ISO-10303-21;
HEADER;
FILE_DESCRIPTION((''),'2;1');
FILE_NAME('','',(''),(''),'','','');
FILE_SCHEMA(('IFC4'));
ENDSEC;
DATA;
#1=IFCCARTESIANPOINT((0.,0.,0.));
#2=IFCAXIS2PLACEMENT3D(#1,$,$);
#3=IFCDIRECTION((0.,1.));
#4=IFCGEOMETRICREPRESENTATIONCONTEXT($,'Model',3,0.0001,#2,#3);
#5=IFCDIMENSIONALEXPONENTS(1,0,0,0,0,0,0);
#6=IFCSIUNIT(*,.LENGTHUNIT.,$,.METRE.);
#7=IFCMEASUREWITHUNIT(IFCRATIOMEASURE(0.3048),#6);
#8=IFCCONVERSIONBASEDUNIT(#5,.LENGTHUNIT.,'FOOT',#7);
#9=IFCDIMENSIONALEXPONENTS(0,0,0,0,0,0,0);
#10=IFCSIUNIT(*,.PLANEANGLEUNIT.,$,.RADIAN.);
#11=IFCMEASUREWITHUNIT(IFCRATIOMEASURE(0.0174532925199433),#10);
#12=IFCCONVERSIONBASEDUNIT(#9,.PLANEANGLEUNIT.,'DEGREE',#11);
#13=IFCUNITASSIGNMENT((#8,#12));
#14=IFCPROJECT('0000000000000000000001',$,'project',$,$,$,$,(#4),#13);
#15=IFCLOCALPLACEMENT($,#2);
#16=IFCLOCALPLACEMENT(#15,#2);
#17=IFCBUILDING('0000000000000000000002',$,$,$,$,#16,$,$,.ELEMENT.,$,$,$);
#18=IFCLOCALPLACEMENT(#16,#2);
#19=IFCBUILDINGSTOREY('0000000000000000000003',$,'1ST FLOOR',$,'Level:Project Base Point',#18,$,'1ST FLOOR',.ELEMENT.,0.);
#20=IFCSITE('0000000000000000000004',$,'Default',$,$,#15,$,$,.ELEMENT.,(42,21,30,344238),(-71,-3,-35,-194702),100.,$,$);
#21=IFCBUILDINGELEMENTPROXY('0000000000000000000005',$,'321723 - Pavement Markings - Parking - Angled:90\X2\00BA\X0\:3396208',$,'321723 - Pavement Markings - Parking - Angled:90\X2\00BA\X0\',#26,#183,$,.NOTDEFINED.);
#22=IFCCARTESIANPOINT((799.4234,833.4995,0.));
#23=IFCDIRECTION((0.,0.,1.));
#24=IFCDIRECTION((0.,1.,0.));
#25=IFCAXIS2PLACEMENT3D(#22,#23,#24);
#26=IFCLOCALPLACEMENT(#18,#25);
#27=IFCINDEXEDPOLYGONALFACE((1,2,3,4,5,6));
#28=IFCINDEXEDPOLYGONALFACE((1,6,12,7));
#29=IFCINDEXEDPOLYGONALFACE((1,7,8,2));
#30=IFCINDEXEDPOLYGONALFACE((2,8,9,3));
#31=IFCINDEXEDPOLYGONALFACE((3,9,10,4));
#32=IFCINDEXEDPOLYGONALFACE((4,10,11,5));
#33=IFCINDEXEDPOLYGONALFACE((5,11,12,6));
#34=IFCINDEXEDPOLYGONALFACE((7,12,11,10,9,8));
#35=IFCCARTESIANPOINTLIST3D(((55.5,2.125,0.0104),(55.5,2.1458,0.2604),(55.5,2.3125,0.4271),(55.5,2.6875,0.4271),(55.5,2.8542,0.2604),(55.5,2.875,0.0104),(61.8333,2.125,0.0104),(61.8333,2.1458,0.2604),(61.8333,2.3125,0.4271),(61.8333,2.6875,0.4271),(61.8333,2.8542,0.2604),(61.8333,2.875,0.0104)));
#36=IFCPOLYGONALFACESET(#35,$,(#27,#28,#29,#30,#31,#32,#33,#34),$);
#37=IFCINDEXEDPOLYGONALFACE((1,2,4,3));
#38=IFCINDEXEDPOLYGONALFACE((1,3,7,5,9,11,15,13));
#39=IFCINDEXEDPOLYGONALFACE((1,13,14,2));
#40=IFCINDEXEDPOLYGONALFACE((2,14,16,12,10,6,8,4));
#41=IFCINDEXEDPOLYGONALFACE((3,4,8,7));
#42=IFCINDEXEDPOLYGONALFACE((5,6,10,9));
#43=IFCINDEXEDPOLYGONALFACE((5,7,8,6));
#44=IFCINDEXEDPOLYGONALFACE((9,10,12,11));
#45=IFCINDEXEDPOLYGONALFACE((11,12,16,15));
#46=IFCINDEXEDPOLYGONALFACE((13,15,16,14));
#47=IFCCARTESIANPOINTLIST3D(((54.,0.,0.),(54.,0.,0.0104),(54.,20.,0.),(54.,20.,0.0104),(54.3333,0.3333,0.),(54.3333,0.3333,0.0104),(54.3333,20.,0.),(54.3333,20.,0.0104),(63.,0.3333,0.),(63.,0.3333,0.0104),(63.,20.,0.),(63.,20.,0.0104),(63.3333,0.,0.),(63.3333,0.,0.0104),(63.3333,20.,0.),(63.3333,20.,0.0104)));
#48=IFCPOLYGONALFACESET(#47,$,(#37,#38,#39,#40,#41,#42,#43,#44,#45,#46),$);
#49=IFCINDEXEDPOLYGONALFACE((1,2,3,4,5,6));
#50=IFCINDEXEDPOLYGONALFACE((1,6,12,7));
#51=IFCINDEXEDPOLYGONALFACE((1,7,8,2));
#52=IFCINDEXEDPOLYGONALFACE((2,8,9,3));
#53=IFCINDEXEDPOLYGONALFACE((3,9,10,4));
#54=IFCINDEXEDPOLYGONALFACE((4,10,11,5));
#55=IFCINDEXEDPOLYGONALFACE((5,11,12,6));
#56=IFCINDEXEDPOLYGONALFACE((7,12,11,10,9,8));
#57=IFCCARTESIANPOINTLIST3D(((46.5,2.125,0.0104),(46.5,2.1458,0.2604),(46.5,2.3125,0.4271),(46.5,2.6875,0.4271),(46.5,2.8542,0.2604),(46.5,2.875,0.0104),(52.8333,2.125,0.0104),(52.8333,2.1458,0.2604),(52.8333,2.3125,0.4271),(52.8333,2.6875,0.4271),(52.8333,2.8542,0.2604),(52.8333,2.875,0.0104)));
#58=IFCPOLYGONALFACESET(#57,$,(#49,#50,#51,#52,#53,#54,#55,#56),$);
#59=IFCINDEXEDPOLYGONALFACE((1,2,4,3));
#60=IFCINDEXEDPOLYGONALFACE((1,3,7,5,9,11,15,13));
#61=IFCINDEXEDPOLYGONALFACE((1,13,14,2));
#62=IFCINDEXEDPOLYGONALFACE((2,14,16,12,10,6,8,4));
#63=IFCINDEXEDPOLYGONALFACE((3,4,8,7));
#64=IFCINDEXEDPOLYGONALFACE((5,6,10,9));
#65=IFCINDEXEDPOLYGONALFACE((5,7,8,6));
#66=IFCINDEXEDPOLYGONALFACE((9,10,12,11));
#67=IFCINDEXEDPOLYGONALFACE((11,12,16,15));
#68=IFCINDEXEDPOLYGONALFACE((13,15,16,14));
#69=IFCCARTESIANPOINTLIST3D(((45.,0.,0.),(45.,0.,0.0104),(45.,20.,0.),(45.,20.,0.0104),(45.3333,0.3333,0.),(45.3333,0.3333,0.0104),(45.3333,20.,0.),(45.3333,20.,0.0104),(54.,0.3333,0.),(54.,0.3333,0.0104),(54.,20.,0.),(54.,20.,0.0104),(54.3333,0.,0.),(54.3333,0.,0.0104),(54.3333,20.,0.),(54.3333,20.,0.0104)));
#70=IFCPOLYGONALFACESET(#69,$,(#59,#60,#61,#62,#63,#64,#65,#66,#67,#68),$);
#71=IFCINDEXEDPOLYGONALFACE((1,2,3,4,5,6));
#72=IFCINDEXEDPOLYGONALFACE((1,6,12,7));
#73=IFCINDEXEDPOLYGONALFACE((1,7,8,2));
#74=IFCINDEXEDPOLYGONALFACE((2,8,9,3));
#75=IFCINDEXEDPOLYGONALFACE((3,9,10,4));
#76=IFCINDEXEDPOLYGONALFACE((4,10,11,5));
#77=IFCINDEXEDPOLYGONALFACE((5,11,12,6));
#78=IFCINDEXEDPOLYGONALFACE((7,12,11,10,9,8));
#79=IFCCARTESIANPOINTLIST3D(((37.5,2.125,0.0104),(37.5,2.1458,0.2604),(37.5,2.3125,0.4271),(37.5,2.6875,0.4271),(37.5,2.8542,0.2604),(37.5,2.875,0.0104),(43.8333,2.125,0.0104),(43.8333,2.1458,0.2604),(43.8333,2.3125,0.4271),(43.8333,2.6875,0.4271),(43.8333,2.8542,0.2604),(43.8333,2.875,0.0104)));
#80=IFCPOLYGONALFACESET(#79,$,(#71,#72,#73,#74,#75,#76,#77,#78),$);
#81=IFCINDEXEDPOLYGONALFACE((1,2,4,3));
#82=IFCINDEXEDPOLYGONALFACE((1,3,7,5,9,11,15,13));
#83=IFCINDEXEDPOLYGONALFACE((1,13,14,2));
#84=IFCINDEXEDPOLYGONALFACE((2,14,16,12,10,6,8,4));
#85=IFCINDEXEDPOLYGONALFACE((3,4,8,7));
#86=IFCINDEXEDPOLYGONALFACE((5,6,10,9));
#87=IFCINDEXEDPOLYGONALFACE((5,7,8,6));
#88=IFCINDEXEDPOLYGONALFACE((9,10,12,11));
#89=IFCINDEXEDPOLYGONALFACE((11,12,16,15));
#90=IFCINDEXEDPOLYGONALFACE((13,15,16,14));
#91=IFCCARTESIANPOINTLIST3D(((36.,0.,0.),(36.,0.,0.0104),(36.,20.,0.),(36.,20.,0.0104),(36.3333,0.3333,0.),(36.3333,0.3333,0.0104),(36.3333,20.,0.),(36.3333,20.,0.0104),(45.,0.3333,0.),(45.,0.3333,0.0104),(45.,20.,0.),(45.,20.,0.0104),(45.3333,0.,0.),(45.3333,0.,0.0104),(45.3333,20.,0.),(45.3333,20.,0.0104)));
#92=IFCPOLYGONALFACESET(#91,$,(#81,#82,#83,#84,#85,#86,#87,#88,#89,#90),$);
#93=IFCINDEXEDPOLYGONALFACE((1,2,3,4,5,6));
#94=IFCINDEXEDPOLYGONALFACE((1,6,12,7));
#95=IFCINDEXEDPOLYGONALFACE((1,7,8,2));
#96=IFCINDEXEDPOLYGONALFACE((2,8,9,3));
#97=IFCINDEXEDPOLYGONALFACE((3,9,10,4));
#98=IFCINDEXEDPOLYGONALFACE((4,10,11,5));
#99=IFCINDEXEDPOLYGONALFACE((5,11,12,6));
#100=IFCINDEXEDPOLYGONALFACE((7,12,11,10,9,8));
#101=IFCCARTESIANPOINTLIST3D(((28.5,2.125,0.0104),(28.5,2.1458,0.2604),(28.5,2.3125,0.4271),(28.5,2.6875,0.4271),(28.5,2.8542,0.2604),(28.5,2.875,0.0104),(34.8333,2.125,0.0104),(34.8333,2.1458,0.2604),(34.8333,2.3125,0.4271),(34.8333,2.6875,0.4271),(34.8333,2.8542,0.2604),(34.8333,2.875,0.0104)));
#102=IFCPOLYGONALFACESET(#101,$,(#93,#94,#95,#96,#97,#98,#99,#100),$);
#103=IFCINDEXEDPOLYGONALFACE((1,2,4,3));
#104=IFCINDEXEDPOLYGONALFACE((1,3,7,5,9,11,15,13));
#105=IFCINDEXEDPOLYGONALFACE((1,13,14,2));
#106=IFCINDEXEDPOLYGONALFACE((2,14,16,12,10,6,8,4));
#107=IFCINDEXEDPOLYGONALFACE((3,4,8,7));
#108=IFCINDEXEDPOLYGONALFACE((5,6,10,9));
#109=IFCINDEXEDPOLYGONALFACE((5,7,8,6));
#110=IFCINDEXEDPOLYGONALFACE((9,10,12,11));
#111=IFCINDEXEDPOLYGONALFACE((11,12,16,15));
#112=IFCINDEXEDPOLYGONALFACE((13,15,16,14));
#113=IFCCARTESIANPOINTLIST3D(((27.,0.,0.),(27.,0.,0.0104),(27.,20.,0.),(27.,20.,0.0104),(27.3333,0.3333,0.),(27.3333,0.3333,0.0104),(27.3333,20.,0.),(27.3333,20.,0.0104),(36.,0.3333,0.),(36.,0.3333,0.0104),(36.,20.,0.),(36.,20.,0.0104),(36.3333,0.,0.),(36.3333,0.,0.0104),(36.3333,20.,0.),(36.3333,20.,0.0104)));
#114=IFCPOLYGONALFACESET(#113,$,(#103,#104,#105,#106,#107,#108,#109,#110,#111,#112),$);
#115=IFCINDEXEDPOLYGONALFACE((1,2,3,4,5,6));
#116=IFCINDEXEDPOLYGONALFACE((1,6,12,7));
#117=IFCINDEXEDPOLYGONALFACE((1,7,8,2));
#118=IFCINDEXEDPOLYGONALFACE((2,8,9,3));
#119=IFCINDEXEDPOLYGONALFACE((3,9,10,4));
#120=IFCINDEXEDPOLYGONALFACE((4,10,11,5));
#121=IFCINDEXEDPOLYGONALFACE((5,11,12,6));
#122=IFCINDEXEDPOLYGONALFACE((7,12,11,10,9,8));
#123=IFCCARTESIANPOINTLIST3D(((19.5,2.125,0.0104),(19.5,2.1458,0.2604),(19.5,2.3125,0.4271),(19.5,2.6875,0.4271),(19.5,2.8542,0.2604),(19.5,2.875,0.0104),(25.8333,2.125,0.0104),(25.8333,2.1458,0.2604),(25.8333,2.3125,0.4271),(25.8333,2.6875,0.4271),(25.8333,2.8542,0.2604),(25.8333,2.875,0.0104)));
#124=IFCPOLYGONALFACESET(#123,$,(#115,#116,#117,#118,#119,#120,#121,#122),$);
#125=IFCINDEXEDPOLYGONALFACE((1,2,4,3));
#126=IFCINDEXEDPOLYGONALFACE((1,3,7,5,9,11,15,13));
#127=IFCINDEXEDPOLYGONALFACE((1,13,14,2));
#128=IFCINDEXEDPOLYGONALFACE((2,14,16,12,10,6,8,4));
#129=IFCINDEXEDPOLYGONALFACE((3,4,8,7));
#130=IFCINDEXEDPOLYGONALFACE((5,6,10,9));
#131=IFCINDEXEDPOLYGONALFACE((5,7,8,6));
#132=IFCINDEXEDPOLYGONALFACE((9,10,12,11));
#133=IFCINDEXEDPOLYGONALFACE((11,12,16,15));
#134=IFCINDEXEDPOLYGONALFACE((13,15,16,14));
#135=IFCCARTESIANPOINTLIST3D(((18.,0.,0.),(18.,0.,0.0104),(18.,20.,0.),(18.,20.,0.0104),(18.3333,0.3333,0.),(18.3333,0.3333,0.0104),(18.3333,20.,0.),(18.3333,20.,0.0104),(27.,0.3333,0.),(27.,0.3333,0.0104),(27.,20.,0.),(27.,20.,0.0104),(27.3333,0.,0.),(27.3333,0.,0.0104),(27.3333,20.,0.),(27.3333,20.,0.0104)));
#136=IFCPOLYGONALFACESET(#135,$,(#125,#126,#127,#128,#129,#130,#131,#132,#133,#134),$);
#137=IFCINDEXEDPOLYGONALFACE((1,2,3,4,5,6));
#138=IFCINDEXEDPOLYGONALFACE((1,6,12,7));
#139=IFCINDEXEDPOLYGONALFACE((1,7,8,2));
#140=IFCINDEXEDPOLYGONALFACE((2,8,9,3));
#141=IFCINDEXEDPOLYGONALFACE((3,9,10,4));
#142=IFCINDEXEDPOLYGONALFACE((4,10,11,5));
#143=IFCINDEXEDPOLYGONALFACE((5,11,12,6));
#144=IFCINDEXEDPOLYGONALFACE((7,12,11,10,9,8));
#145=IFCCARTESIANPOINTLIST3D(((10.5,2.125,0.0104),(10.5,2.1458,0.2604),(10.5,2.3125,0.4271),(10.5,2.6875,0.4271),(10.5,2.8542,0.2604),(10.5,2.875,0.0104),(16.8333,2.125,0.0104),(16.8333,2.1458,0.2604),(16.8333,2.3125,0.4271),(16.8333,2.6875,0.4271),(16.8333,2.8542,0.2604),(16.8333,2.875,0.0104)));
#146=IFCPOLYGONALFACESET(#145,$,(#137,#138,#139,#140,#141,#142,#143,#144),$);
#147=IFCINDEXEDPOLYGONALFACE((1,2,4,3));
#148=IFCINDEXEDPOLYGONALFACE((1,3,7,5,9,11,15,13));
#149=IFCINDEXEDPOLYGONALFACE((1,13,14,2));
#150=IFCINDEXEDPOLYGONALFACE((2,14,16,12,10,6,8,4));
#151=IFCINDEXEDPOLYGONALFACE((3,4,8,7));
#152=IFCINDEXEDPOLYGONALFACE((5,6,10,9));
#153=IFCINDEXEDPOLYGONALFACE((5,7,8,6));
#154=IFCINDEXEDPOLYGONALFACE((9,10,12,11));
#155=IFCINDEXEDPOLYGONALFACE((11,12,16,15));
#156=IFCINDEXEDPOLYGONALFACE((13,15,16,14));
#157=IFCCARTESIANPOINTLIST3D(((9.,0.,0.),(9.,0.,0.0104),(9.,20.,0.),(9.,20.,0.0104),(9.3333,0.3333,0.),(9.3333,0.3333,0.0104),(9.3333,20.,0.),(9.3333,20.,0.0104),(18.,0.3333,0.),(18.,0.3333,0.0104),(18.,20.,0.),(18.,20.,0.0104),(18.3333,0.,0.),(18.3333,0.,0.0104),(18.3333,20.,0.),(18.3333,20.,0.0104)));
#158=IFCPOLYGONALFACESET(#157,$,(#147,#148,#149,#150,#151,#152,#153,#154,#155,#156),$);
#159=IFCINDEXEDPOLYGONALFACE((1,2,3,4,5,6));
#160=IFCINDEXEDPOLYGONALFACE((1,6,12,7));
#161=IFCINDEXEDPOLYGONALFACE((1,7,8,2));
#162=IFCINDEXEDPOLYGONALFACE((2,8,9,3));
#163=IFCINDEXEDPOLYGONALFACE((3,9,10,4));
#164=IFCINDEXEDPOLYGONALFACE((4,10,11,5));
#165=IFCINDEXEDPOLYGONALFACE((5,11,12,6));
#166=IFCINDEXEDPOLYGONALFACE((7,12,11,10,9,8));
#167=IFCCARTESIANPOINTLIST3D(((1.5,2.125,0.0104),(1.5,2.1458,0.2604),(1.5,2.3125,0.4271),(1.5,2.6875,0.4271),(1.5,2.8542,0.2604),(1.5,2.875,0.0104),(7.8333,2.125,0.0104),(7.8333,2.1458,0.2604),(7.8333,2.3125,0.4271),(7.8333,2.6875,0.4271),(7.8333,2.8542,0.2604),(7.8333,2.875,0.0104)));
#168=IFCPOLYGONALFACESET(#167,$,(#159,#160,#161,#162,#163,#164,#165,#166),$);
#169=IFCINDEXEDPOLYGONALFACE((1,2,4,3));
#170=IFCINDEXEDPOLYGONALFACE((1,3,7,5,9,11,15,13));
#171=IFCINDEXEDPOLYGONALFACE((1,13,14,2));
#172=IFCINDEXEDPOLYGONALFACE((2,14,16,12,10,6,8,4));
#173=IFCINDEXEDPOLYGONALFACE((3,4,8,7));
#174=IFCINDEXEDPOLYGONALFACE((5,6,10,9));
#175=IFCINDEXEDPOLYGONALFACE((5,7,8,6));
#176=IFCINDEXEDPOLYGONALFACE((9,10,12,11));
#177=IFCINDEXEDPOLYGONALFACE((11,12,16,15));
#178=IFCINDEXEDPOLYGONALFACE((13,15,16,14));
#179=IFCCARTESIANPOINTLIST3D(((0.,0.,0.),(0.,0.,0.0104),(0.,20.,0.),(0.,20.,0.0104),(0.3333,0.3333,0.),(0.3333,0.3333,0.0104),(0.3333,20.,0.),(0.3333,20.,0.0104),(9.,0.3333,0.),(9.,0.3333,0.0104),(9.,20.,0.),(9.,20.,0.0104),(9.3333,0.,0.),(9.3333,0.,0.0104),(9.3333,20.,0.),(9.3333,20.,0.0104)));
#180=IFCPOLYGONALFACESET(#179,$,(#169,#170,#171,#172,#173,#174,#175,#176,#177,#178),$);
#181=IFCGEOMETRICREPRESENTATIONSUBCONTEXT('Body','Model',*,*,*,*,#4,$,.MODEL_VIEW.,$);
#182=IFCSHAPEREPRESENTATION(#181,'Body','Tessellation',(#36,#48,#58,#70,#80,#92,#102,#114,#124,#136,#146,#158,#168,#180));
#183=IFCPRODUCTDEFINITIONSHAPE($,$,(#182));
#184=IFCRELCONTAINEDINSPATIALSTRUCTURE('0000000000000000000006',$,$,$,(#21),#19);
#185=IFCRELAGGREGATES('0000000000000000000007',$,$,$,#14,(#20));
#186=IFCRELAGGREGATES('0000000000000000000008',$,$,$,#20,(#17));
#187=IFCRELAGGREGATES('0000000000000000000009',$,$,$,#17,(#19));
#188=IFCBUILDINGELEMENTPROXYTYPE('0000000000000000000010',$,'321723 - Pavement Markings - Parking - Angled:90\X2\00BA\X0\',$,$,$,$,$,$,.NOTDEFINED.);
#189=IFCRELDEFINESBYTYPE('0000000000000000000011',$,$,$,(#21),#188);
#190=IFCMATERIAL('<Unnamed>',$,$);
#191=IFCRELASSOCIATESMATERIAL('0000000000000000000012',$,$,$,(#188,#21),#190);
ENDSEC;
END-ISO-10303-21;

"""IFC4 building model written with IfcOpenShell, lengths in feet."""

from ifc_helpers import new_model, entity, si_unit, converted_unit, direction, frame, origin, place, context, subcontext, project, spatial, polyline, outline, extrude, source, transform, mapped, material, type_object, type_shapes, element, save


model = new_model("IFC4")

# Units and contexts
model_context = context("Model", 3, precision=0.0001, world=origin(), true_north=direction((0.0, 1.0)))
body_context = subcontext(model_context, "Body", "Model", "MODEL_VIEW")
ifc_project = project(units=[converted_unit("LENGTHUNIT", "FOOT", entity("IfcRatioMeasure", 0.3048), si_unit("LENGTHUNIT", "METRE"), dimensions=[1, 0, 0, 0, 0, 0, 0]), converted_unit("PLANEANGLEUNIT", "DEGREE", entity("IfcRatioMeasure", 0.0174532925199433), si_unit("PLANEANGLEUNIT", "RADIAN"), dimensions=[0, 0, 0, 0, 0, 0, 0])], contexts=[model_context])

# Site, building, storey
site_placement = place(None, origin())
site = spatial("IfcSite", under=ifc_project, at=site_placement, Name="Default", CompositionType="ELEMENT", RefLatitude=(42, 21, 30, 344238), RefLongitude=(-71, -3, -35, -194702), RefElevation=100.0)
building_placement = place(site_placement, origin())
building = spatial("IfcBuilding", under=site, at=building_placement, CompositionType="ELEMENT")
storey_placement = place(building_placement, origin())
storey = spatial("IfcBuildingStorey", under=building, at=storey_placement, Name="1ST FLOOR", ObjectType="Level:Project Base Point", LongName="1ST FLOOR", CompositionType="ELEMENT", Elevation=0.0)

# Building element proxy
ifc_material_1 = material(Name="<Unnamed>")
building_element_proxy_type_1 = type_object("IfcBuildingElementProxyType", Name="321723 - Pavement Markings - Parking - Angled:90º", PredefinedType="NOTDEFINED", material=ifc_material_1)
shared_shape_1 = source(origin(), body_context, "Body", "SweptSolid", [
    extrude(outline(polyline([(-0.375, -0.2222), (0.375, -0.2222), (0.3542, 0.0278), (0.1875, 0.1944), (-0.1875, 0.1944), (-0.3542, 0.0278), (-0.375, -0.2222)])), frame((55.5, 2.5, 0.2326), z_axis=(1.0, 0.0, 0.0), x_axis=(0.0, 1.0, 0.0)), (0.0, 0.0, 1.0), 6.3333),
    extrude(outline(polyline([(-4.6667, -10.0833), (4.6667, -10.0833), (4.6667, 9.9167), (4.3333, 9.9167), (4.3333, -9.75), (-4.3333, -9.75), (-4.3333, 9.9167), (-4.6667, 9.9167), (-4.6667, -10.0833)])), frame((58.6667, 10.0833, 0.0)), (0.0, 0.0, 1.0), 0.0104),
    extrude(outline(polyline([(-0.375, -0.2222), (0.375, -0.2222), (0.3542, 0.0278), (0.1875, 0.1944), (-0.1875, 0.1944), (-0.3542, 0.0278), (-0.375, -0.2222)])), frame((46.5, 2.5, 0.2326), z_axis=(1.0, 0.0, 0.0), x_axis=(0.0, 1.0, 0.0)), (0.0, 0.0, 1.0), 6.3333),
    extrude(outline(polyline([(-4.6667, -10.0833), (4.6667, -10.0833), (4.6667, 9.9167), (4.3333, 9.9167), (4.3333, -9.75), (-4.3333, -9.75), (-4.3333, 9.9167), (-4.6667, 9.9167), (-4.6667, -10.0833)])), frame((49.6667, 10.0833, 0.0)), (0.0, 0.0, 1.0), 0.0104),
    extrude(outline(polyline([(-0.375, -0.2222), (0.375, -0.2222), (0.3542, 0.0278), (0.1875, 0.1944), (-0.1875, 0.1944), (-0.3542, 0.0278), (-0.375, -0.2222)])), frame((37.5, 2.5, 0.2326), z_axis=(1.0, 0.0, 0.0), x_axis=(0.0, 1.0, 0.0)), (0.0, 0.0, 1.0), 6.3333),
    extrude(outline(polyline([(-4.6667, -10.0833), (4.6667, -10.0833), (4.6667, 9.9167), (4.3333, 9.9167), (4.3333, -9.75), (-4.3333, -9.75), (-4.3333, 9.9167), (-4.6667, 9.9167), (-4.6667, -10.0833)])), frame((40.6667, 10.0833, 0.0)), (0.0, 0.0, 1.0), 0.0104),
    extrude(outline(polyline([(-0.375, -0.2222), (0.375, -0.2222), (0.3542, 0.0278), (0.1875, 0.1944), (-0.1875, 0.1944), (-0.3542, 0.0278), (-0.375, -0.2222)])), frame((28.5, 2.5, 0.2326), z_axis=(1.0, 0.0, 0.0), x_axis=(0.0, 1.0, 0.0)), (0.0, 0.0, 1.0), 6.3333),
    extrude(outline(polyline([(-4.6667, -10.0833), (4.6667, -10.0833), (4.6667, 9.9167), (4.3333, 9.9167), (4.3333, -9.75), (-4.3333, -9.75), (-4.3333, 9.9167), (-4.6667, 9.9167), (-4.6667, -10.0833)])), frame((31.6667, 10.0833, 0.0)), (0.0, 0.0, 1.0), 0.0104),
    extrude(outline(polyline([(-0.375, -0.2222), (0.375, -0.2222), (0.3542, 0.0278), (0.1875, 0.1944), (-0.1875, 0.1944), (-0.3542, 0.0278), (-0.375, -0.2222)])), frame((19.5, 2.5, 0.2326), z_axis=(1.0, 0.0, 0.0), x_axis=(0.0, 1.0, 0.0)), (0.0, 0.0, 1.0), 6.3333),
    extrude(outline(polyline([(-4.6667, -10.0833), (4.6667, -10.0833), (4.6667, 9.9167), (4.3333, 9.9167), (4.3333, -9.75), (-4.3333, -9.75), (-4.3333, 9.9167), (-4.6667, 9.9167), (-4.6667, -10.0833)])), frame((22.6667, 10.0833, 0.0)), (0.0, 0.0, 1.0), 0.0104),
    extrude(outline(polyline([(-0.375, -0.2222), (0.375, -0.2222), (0.3542, 0.0278), (0.1875, 0.1944), (-0.1875, 0.1944), (-0.3542, 0.0278), (-0.375, -0.2222)])), frame((10.5, 2.5, 0.2326), z_axis=(1.0, 0.0, 0.0), x_axis=(0.0, 1.0, 0.0)), (0.0, 0.0, 1.0), 6.3333),
    extrude(outline(polyline([(-4.6667, -10.0833), (4.6667, -10.0833), (4.6667, 9.9167), (4.3333, 9.9167), (4.3333, -9.75), (-4.3333, -9.75), (-4.3333, 9.9167), (-4.6667, 9.9167), (-4.6667, -10.0833)])), frame((13.6667, 10.0833, 0.0)), (0.0, 0.0, 1.0), 0.0104),
    extrude(outline(polyline([(-0.375, -0.2222), (0.375, -0.2222), (0.3542, 0.0278), (0.1875, 0.1944), (-0.1875, 0.1944), (-0.3542, 0.0278), (-0.375, -0.2222)])), frame((1.5, 2.5, 0.2326), z_axis=(1.0, 0.0, 0.0), x_axis=(0.0, 1.0, 0.0)), (0.0, 0.0, 1.0), 6.3333),
    extrude(outline(polyline([(-4.6667, -10.0833), (4.6667, -10.0833), (4.6667, 9.9167), (4.3333, 9.9167), (4.3333, -9.75), (-4.3333, -9.75), (-4.3333, 9.9167), (-4.6667, 9.9167), (-4.6667, -10.0833)])), frame((4.6667, 10.0833, 0.0)), (0.0, 0.0, 1.0), 0.0104),
])
type_shapes(building_element_proxy_type_1, [shared_shape_1])
proxy_1_placement = place(storey_placement, frame((799.4234, 833.4995, 0.0), z_axis=(0.0, 0.0, 1.0), x_axis=(0.0, 1.0, 0.0)))
element("IfcBuildingElementProxy", 1, at=proxy_1_placement, inside=storey, type_object=building_element_proxy_type_1, material=ifc_material_1, Name="321723 - Pavement Markings - Parking - Angled:90º:3396208", ObjectType="321723 - Pavement Markings - Parking - Angled:90º", PredefinedType="NOTDEFINED", context=body_context, shape_type="MappedRepresentation", body=[
    mapped(shared_shape_1, transform((0.0, 0.0, 0.0), scale=1.0)),
])

save(model, "model.ifc")
